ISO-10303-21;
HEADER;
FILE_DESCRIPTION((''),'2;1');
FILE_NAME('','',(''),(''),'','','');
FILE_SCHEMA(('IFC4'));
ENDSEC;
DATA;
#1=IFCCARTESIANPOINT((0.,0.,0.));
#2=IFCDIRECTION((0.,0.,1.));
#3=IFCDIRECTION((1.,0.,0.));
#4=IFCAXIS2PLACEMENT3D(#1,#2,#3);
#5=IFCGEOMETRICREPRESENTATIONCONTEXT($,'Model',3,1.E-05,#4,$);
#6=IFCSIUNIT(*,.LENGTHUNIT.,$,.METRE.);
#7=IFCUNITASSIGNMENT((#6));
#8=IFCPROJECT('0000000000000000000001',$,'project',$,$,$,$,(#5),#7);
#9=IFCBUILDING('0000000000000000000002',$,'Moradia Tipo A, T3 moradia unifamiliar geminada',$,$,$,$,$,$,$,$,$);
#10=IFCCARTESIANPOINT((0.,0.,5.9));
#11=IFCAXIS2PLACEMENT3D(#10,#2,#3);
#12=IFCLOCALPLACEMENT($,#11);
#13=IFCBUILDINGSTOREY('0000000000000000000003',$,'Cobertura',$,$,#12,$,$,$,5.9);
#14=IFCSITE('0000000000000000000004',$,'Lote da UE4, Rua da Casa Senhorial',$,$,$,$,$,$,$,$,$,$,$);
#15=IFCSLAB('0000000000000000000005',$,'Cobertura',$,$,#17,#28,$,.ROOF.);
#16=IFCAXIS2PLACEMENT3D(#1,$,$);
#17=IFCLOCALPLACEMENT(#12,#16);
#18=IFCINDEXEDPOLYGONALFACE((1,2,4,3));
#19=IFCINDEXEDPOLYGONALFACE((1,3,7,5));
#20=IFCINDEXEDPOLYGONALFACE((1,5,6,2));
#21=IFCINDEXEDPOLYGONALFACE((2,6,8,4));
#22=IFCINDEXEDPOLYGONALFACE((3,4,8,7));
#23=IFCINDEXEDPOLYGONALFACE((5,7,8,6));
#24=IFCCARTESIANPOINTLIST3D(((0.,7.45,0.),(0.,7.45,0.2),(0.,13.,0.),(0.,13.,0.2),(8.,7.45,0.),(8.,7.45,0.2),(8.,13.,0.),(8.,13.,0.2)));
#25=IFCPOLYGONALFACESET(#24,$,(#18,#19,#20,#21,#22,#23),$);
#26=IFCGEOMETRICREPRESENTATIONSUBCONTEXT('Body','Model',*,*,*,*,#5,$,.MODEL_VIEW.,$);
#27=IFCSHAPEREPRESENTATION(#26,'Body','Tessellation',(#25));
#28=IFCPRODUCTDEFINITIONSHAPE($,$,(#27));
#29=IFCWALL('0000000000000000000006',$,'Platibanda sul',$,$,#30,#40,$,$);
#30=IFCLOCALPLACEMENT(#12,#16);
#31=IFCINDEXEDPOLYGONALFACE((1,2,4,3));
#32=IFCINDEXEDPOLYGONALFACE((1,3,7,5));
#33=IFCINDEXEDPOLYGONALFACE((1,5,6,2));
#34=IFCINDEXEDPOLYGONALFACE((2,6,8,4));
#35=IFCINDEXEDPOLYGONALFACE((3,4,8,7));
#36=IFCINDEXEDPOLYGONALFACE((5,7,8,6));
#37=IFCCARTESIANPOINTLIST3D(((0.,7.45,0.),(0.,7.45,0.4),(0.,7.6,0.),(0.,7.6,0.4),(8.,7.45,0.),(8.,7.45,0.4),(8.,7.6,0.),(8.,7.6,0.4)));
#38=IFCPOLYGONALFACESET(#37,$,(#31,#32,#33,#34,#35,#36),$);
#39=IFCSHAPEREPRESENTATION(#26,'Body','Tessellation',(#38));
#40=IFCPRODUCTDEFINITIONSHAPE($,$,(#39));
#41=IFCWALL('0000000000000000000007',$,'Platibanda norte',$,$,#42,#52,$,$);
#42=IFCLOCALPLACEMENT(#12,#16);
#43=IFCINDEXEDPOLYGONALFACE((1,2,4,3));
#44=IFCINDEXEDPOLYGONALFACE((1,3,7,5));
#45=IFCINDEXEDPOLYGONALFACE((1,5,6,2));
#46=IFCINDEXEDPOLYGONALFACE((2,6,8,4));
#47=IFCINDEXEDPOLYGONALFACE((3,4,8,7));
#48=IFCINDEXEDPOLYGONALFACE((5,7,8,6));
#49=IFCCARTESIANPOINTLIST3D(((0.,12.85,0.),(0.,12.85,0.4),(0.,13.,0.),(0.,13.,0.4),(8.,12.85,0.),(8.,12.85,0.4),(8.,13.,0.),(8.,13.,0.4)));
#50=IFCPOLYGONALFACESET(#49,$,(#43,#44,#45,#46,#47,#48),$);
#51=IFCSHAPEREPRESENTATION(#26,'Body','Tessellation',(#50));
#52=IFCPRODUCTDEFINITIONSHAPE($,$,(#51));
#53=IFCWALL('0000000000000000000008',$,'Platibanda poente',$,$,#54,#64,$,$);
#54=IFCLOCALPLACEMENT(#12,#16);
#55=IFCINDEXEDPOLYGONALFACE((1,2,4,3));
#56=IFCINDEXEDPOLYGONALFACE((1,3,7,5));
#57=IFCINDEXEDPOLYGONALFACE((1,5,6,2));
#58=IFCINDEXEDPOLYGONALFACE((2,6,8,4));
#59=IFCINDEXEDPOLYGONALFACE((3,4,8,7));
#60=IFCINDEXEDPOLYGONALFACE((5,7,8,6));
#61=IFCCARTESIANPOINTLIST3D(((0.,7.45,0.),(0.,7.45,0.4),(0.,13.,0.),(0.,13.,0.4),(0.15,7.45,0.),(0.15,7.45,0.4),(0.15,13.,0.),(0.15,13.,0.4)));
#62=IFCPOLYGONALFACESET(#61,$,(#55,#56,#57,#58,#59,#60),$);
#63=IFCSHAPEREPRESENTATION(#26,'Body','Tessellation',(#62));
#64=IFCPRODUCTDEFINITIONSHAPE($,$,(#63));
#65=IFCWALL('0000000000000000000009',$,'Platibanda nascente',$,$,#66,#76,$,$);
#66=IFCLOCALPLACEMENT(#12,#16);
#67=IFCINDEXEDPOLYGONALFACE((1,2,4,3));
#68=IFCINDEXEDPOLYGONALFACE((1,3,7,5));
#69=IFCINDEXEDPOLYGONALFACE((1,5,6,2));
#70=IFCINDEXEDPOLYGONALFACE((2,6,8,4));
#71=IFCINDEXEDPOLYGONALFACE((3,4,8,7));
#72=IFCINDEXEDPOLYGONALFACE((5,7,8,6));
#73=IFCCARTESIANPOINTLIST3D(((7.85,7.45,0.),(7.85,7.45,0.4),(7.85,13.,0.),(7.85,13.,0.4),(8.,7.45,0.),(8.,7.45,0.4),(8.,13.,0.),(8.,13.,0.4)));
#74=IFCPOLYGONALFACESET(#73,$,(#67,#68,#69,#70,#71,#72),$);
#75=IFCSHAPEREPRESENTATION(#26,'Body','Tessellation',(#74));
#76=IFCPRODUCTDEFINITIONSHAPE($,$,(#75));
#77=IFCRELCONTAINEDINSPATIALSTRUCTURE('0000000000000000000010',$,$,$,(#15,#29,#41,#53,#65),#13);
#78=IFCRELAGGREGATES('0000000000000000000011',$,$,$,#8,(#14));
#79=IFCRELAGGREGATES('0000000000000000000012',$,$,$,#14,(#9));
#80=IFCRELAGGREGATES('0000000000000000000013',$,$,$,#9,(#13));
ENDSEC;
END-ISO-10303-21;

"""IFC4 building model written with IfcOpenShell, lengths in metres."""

from ifc_helpers import new_model, si_unit, frame, origin_with_axes, place, context, subcontext, project, spatial, indexed_curve, outline, extrude, element, save


model = new_model("IFC4")

# Units and contexts
model_context = context("Model", 3, precision=1e-05, world=origin_with_axes())
body_context = subcontext(model_context, "Body", "Model", "MODEL_VIEW")
ifc_project = project(units=[si_unit("LENGTHUNIT", "METRE")], contexts=[model_context])

# Site, building, storey
site = spatial("IfcSite", under=ifc_project, Name="Lote da UE4, Rua da Casa Senhorial")
building = spatial("IfcBuilding", under=site, Name="Moradia Tipo A, T3 moradia unifamiliar geminada")
storey_placement = place(None, frame((0.0, 0.0, 5.9), z_axis=(0.0, 0.0, 1.0), x_axis=(1.0, 0.0, 0.0)))
storey = spatial("IfcBuildingStorey", under=building, at=storey_placement, Name="Cobertura", Elevation=5.9)

# Slab
slab_placement = place(storey_placement, frame((0.0, 7.45, 0.0), z_axis=(0.0, 0.0, 1.0), x_axis=(1.0, 0.0, 0.0)))
element("IfcSlab", 1, at=slab_placement, inside=storey, Name="Cobertura", PredefinedType="ROOF", context=body_context, shape_type="SweptSolid", body=[
    extrude(outline(indexed_curve([(0.0, 0.0), (8.0, 0.0), (8.0, 5.55), (0.0, 5.55), (0.0, 0.0)])), None, (0.0, 0.0, 1.0), 0.2),
])

# Walls
for number, where, z_axis, x_axis, name in (
    (2, (0.0, 7.45, 0.0), (0.0, 0.0, 1.0), (1.0, 0.0, 0.0), "Platibanda sul"),
    (3, (0.0, 12.85, 0.0), (0.0, 0.0, 1.0), (1.0, 0.0, 0.0), "Platibanda norte"),
):
    element("IfcWall", number, at=place(storey_placement, frame(where, z_axis=z_axis, x_axis=x_axis)), inside=storey, Name=name, context=body_context, shape_type="SweptSolid", body=[
        extrude(outline(indexed_curve([(0.0, 0.0), (0.0, 0.15), (8.0, 0.15), (8.0, 0.0), (0.0, 0.0)], self_intersect=False)), origin_with_axes(), (0.0, 0.0, 1.0), 0.4),
    ])
for number, where, z_axis, x_axis, name in (
    (4, (0.15, 7.45, 0.0), (0.0, 0.0, 1.0), (0.0, 1.0, 0.0), "Platibanda poente"),
    (5, (8.0, 7.45, 0.0), (0.0, 0.0, 1.0), (0.0, 1.0, 0.0), "Platibanda nascente"),
):
    element("IfcWall", number, at=place(storey_placement, frame(where, z_axis=z_axis, x_axis=x_axis)), inside=storey, Name=name, context=body_context, shape_type="SweptSolid", body=[
        extrude(outline(indexed_curve([(0.0, 0.0), (0.0, 0.15), (5.55, 0.15), (5.55, 0.0), (0.0, 0.0)], self_intersect=False)), origin_with_axes(), (0.0, 0.0, 1.0), 0.4),
    ])

save(model, "model.ifc")
